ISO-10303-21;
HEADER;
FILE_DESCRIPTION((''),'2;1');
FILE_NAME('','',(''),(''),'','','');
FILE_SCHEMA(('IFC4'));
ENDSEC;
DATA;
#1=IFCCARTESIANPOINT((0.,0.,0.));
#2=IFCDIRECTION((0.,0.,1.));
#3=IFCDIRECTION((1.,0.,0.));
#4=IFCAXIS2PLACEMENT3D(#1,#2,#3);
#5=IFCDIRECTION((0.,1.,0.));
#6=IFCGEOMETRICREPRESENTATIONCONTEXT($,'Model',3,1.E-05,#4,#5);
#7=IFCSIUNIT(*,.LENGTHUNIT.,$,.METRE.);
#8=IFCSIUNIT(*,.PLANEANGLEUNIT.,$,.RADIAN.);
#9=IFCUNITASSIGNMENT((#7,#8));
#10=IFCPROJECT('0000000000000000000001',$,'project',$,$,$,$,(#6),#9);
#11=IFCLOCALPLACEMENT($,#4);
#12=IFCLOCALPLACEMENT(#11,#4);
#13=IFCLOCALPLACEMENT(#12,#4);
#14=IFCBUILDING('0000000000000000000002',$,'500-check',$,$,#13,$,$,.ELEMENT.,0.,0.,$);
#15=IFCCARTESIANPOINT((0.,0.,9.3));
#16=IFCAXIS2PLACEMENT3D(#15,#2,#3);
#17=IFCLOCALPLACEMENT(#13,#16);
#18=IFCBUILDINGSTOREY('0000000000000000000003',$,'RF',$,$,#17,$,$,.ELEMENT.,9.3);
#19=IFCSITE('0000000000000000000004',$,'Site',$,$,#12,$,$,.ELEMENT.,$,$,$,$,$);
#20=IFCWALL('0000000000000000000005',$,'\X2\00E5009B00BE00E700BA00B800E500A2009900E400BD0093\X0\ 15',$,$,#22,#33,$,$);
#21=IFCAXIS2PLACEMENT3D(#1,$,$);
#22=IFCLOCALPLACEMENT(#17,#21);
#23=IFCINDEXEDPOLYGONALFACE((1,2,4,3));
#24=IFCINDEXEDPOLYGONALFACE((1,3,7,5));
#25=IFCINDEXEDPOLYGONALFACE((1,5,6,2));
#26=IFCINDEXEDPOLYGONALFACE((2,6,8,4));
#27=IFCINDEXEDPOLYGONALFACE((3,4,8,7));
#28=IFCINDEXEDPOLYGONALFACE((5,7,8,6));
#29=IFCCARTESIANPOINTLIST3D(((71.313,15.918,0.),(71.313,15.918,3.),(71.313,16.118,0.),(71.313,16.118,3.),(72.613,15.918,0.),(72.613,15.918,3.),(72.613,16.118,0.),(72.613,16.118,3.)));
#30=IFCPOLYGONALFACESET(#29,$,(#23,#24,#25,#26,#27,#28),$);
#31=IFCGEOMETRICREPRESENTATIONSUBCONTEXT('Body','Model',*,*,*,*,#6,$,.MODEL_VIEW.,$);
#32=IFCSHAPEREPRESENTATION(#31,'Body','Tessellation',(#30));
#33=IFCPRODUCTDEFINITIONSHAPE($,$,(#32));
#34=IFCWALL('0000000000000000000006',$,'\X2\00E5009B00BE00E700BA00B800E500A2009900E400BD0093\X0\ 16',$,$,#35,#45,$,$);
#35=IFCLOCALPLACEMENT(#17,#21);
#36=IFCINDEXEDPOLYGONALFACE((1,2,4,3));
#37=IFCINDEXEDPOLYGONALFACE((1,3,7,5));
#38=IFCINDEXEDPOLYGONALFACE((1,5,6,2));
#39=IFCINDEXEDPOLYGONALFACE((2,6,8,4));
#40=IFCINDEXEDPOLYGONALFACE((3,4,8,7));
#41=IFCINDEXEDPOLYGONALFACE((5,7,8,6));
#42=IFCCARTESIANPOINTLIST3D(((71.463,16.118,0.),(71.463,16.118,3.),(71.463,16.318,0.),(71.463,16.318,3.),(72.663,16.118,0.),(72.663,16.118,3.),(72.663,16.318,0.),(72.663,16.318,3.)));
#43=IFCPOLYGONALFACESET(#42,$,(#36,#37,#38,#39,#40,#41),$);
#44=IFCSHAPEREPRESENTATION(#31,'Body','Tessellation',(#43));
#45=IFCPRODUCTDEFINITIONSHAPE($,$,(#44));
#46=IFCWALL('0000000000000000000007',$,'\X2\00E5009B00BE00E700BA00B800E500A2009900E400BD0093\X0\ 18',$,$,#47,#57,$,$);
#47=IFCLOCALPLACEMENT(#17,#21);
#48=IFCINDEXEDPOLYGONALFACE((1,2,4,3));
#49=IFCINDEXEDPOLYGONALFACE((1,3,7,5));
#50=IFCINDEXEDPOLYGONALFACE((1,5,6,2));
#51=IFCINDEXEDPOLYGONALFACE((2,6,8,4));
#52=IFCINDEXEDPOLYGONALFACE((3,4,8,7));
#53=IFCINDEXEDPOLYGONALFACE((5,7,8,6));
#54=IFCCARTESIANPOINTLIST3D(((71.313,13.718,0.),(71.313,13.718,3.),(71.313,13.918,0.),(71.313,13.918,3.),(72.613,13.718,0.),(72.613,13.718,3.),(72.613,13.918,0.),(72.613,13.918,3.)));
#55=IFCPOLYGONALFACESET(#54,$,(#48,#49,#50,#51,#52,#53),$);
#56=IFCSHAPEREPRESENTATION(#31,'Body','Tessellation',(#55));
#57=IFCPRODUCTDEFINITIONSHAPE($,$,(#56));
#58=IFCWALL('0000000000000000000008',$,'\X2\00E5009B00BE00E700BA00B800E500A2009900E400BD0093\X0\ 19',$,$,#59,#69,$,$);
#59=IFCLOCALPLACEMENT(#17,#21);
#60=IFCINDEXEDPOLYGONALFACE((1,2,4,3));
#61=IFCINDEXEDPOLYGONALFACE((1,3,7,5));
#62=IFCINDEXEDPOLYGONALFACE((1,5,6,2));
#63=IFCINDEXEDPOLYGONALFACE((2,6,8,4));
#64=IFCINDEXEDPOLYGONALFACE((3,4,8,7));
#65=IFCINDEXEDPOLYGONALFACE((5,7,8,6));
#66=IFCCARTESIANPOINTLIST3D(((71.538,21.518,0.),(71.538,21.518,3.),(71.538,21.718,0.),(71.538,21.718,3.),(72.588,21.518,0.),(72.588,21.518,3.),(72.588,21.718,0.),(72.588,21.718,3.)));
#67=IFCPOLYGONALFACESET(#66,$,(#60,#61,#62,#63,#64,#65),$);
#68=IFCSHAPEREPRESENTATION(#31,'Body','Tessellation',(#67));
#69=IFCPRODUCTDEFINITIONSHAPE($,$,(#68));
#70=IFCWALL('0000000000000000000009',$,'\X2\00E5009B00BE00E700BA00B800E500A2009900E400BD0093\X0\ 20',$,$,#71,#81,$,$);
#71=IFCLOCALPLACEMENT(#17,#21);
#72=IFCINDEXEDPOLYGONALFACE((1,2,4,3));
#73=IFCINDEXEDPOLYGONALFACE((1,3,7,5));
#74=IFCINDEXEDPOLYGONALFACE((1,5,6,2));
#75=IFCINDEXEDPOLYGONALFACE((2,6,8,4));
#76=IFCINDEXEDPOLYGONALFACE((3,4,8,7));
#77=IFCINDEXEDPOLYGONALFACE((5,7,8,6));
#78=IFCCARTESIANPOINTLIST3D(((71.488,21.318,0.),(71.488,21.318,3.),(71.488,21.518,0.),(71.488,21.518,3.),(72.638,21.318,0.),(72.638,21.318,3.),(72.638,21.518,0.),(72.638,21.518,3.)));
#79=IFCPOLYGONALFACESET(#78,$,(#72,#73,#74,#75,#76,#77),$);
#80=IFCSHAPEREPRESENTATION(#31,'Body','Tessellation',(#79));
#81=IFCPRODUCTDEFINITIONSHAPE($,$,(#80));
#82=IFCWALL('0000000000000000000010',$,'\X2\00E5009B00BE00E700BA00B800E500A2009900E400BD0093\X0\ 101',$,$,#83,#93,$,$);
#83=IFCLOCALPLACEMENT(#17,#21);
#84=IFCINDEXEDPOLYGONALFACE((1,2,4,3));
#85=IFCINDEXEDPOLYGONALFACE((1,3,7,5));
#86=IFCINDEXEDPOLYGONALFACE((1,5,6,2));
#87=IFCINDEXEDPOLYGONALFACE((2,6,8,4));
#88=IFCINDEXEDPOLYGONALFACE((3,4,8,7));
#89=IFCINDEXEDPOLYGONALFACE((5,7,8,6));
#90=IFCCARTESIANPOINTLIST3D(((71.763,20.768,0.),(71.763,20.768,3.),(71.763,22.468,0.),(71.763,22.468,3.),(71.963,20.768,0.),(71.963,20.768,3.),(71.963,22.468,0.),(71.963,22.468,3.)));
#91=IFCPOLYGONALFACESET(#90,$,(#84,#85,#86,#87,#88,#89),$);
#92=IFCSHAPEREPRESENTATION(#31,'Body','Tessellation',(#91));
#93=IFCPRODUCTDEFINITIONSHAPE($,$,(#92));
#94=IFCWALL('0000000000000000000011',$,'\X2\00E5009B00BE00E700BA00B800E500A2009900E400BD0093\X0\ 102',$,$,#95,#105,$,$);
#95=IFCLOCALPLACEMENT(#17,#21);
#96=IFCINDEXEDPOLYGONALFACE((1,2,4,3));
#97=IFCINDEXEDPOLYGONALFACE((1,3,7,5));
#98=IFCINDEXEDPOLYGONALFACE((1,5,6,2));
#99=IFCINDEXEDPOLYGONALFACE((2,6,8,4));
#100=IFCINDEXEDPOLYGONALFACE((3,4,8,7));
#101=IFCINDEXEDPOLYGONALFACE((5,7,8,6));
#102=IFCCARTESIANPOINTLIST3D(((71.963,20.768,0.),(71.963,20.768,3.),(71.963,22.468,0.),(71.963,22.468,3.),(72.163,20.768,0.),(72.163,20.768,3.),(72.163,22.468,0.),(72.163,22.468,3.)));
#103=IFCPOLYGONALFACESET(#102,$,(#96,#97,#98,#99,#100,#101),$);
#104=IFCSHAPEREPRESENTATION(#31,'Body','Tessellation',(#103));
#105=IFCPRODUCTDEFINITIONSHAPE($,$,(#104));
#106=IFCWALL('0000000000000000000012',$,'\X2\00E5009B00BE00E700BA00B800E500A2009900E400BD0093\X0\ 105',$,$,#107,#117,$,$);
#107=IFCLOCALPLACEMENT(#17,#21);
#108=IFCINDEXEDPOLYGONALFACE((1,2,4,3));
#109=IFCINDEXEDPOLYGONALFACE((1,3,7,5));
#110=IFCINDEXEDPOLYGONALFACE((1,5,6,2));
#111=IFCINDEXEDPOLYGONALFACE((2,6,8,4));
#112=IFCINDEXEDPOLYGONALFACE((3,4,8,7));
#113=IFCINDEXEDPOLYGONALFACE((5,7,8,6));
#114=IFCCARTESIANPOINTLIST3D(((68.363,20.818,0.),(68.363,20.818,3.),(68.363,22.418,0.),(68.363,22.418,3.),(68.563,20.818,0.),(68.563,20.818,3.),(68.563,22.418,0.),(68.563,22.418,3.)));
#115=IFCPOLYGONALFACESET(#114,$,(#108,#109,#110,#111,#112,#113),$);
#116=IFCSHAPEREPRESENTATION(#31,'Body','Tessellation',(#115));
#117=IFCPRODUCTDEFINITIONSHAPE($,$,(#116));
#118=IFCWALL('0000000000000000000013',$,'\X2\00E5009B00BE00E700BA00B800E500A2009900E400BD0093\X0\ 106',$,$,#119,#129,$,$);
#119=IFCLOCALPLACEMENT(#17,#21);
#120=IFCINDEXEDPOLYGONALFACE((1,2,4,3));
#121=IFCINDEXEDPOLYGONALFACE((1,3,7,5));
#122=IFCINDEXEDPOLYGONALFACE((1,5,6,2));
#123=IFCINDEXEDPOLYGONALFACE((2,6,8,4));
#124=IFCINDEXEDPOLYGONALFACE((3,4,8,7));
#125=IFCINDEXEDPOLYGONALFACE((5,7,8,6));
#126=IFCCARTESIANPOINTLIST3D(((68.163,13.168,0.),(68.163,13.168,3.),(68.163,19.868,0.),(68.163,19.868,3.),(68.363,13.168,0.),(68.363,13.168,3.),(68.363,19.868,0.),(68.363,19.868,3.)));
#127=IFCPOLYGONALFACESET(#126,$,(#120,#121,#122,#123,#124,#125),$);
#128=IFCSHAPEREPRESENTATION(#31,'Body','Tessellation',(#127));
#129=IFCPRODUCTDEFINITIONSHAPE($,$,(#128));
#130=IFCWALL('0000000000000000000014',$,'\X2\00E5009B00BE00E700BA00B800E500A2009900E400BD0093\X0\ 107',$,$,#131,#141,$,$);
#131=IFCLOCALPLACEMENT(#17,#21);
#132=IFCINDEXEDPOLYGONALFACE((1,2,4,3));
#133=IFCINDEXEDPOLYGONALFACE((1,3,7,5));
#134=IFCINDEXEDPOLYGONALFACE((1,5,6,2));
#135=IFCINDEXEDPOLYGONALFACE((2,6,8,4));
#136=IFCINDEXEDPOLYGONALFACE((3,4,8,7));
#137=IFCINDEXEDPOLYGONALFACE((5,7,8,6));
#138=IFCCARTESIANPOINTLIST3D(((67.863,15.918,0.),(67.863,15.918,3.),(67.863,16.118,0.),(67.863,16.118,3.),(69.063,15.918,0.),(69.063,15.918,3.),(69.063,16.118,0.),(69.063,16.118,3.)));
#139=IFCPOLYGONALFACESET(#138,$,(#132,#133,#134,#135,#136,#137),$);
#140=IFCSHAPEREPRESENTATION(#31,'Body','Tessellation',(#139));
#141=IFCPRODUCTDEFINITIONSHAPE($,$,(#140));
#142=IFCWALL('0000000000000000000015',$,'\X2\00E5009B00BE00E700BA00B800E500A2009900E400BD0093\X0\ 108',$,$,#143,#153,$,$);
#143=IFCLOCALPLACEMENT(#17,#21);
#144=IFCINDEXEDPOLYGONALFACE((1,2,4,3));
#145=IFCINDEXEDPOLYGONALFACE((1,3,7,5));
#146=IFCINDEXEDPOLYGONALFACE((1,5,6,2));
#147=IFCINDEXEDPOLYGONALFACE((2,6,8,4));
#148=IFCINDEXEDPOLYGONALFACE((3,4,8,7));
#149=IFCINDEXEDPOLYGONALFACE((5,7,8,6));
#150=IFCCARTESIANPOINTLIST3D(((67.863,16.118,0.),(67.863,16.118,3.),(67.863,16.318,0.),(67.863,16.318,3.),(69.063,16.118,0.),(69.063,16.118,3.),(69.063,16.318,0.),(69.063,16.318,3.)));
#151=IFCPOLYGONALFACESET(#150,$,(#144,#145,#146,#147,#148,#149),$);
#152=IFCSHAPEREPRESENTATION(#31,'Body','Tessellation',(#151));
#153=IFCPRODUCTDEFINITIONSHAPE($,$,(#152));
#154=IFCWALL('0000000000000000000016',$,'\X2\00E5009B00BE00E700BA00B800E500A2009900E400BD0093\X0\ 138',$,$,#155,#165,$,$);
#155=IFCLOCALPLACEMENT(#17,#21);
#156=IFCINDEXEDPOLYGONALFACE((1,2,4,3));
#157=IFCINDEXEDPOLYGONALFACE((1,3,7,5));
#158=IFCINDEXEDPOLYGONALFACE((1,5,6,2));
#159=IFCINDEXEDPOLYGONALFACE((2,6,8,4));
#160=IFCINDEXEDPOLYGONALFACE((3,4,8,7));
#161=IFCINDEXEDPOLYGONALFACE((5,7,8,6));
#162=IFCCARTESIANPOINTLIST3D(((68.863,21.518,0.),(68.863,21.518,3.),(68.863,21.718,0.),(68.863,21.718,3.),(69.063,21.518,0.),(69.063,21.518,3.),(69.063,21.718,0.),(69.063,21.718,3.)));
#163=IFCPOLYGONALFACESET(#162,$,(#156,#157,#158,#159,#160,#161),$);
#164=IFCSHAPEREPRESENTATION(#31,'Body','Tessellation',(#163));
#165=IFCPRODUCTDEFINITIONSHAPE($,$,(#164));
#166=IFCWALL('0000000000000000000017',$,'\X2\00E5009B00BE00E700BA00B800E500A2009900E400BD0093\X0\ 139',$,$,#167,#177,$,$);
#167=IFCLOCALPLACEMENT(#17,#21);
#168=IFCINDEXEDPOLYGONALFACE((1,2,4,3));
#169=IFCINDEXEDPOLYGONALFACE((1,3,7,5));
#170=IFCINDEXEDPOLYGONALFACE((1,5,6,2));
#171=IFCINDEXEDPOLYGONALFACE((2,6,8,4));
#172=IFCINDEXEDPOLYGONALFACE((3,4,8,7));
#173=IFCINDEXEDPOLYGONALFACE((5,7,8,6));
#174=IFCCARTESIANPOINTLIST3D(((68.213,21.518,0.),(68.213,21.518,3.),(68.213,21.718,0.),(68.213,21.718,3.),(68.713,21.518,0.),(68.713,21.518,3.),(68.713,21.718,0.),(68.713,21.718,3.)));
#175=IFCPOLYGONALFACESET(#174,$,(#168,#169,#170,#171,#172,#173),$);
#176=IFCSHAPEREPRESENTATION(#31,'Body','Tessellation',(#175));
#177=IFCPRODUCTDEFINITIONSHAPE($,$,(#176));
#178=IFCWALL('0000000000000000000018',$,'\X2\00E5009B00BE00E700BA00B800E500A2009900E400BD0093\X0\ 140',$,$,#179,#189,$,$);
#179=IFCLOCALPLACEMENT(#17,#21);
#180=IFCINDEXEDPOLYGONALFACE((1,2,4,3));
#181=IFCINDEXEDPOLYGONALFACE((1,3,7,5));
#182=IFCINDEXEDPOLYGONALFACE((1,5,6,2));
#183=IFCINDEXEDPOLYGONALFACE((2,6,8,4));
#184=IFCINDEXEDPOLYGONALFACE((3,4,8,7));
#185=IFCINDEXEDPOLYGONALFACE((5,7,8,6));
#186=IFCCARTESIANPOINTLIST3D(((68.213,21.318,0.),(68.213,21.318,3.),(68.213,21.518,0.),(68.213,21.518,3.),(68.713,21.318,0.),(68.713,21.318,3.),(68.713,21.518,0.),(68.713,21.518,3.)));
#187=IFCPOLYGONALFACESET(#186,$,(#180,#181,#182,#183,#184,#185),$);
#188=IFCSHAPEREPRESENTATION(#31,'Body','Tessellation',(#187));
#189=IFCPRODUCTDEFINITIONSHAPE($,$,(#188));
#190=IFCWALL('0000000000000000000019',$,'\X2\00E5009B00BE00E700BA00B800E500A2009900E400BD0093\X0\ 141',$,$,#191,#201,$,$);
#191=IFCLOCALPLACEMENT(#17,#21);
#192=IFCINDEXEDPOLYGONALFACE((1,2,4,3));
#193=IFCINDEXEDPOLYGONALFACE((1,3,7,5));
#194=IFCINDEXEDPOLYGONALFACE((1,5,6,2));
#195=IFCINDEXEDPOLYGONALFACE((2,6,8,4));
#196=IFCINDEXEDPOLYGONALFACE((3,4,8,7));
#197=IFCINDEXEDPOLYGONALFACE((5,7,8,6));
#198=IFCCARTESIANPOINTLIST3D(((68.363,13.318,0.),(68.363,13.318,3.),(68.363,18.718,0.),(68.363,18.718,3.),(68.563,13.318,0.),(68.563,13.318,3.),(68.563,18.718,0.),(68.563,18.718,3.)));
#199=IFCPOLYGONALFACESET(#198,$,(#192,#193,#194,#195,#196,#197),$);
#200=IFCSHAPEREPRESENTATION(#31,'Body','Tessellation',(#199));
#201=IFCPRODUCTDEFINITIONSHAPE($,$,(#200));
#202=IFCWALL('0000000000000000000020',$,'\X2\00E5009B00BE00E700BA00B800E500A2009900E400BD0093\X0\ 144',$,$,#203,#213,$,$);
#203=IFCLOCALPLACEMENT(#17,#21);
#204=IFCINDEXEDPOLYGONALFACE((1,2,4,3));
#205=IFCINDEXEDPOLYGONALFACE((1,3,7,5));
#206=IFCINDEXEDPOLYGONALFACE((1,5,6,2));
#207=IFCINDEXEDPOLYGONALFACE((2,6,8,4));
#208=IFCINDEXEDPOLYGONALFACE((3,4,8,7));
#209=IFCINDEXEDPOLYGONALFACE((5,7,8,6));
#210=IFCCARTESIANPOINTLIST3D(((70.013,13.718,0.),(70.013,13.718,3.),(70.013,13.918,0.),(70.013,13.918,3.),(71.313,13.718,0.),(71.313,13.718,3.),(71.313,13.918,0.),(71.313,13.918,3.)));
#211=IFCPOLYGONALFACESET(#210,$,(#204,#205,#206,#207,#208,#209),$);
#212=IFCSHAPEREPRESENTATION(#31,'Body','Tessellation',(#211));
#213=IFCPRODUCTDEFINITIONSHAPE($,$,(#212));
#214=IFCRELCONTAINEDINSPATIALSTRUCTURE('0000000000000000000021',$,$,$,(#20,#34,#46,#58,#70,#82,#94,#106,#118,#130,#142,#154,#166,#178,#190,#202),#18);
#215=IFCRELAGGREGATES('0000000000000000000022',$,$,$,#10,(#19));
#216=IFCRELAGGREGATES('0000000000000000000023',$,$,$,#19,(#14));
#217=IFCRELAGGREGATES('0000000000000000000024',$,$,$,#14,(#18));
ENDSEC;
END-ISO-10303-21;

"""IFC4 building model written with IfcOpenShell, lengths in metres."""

from ifc_helpers import new_model, si_unit, direction, frame, frame_2d, origin_with_axes, place, context, subcontext, project, spatial, rectangle, extrude, element, save


model = new_model("IFC4")

# Units and contexts
model_context = context("Model", 3, precision=1e-05, world=origin_with_axes(), true_north=direction((0.0, 1.0, 0.0)))
body_context = subcontext(model_context, "Body", "Model", "MODEL_VIEW")
ifc_project = project(units=[si_unit("LENGTHUNIT", "METRE"), si_unit("PLANEANGLEUNIT", "RADIAN")], contexts=[model_context])

# Site, building, storey
placement = place(None, origin_with_axes())
site_placement = place(placement, origin_with_axes())
site = spatial("IfcSite", under=ifc_project, at=site_placement, Name="Site", CompositionType="ELEMENT")
building_placement = place(site_placement, origin_with_axes())
building = spatial("IfcBuilding", under=site, at=building_placement, Name="500-check", CompositionType="ELEMENT", ElevationOfRefHeight=0.0, ElevationOfTerrain=0.0)
storey_placement = place(building_placement, frame((0.0, 0.0, 9.3), z_axis=(0.0, 0.0, 1.0), x_axis=(1.0, 0.0, 0.0)))
storey = spatial("IfcBuildingStorey", under=building, at=storey_placement, Name="RF", CompositionType="ELEMENT", Elevation=9.3)

# Walls
wall_1_placement = place(storey_placement, frame((71.963, 16.018, 0.0), z_axis=(0.0, 0.0, 1.0), x_axis=(1.0, 0.0, 0.0)))
element("IfcWall", 1, at=wall_1_placement, inside=storey, Name="å\u009b¾çº¸å¢\u0099ä½\u0093 15", context=body_context, shape_type="SweptSolid", body=[
    extrude(rectangle(XDim=1.3, YDim=0.2, at=frame_2d((0.0, 0.0), x_axis=(1.0, 0.0, 0.0))), frame((0.0, 0.0, 0.0), z_axis=(0.0, 0.0, 1.0)), (0.0, 0.0, 1.0), 3.0),
])
wall_2_placement = place(storey_placement, frame((72.063, 16.218, 0.0), z_axis=(0.0, 0.0, 1.0), x_axis=(1.0, 0.0, 0.0)))
element("IfcWall", 2, at=wall_2_placement, inside=storey, Name="å\u009b¾çº¸å¢\u0099ä½\u0093 16", context=body_context, shape_type="SweptSolid", body=[
    extrude(rectangle(XDim=1.2, YDim=0.2, at=frame_2d((0.0, 0.0), x_axis=(1.0, 0.0, 0.0))), frame((0.0, 0.0, 0.0), z_axis=(0.0, 0.0, 1.0)), (0.0, 0.0, 1.0), 3.0),
])
wall_3_placement = place(storey_placement, frame((71.963, 13.818, 0.0), z_axis=(0.0, 0.0, 1.0), x_axis=(1.0, 0.0, 0.0)))
element("IfcWall", 3, at=wall_3_placement, inside=storey, Name="å\u009b¾çº¸å¢\u0099ä½\u0093 18", context=body_context, shape_type="SweptSolid", body=[
    extrude(rectangle(XDim=1.3, YDim=0.2, at=frame_2d((0.0, 0.0), x_axis=(1.0, 0.0, 0.0))), frame((0.0, 0.0, 0.0), z_axis=(0.0, 0.0, 1.0)), (0.0, 0.0, 1.0), 3.0),
])
wall_4_placement = place(storey_placement, frame((72.063, 21.618, 0.0), z_axis=(0.0, 0.0, 1.0), x_axis=(1.0, 0.0, 0.0)))
element("IfcWall", 4, at=wall_4_placement, inside=storey, Name="å\u009b¾çº¸å¢\u0099ä½\u0093 19", context=body_context, shape_type="SweptSolid", body=[
    extrude(rectangle(XDim=1.05, YDim=0.2, at=frame_2d((0.0, 0.0), x_axis=(1.0, 0.0, 0.0))), frame((0.0, 0.0, 0.0), z_axis=(0.0, 0.0, 1.0)), (0.0, 0.0, 1.0), 3.0),
])
wall_5_placement = place(storey_placement, frame((72.063, 21.418, 0.0), z_axis=(0.0, 0.0, 1.0), x_axis=(1.0, 0.0, 0.0)))
element("IfcWall", 5, at=wall_5_placement, inside=storey, Name="å\u009b¾çº¸å¢\u0099ä½\u0093 20", context=body_context, shape_type="SweptSolid", body=[
    extrude(rectangle(XDim=1.15, YDim=0.2, at=frame_2d((0.0, 0.0), x_axis=(1.0, 0.0, 0.0))), frame((0.0, 0.0, 0.0), z_axis=(0.0, 0.0, 1.0)), (0.0, 0.0, 1.0), 3.0),
])
for number, where, z_axis, x_axis, name in (
    (6, (71.863, 21.618, 0.0), (0.0, 0.0, 1.0), (0.0, 1.0, 0.0), "å\u009b¾çº¸å¢\u0099ä½\u0093 101"),
    (7, (72.063, 21.618, 0.0), (0.0, 0.0, 1.0), (0.0, 1.0, 0.0), "å\u009b¾çº¸å¢\u0099ä½\u0093 102"),
):
    element("IfcWall", number, at=place(storey_placement, frame(where, z_axis=z_axis, x_axis=x_axis)), inside=storey, Name=name, context=body_context, shape_type="SweptSolid", body=[
        extrude(rectangle(XDim=1.7, YDim=0.2, at=frame_2d((0.0, 0.0), x_axis=(1.0, 0.0, 0.0))), frame((0.0, 0.0, 0.0), z_axis=(0.0, 0.0, 1.0)), (0.0, 0.0, 1.0), 3.0),
    ])
wall_6_placement = place(storey_placement, frame((68.463, 21.618, 0.0), z_axis=(0.0, 0.0, 1.0), x_axis=(0.0, 1.0, 0.0)))
element("IfcWall", 8, at=wall_6_placement, inside=storey, Name="å\u009b¾çº¸å¢\u0099ä½\u0093 105", context=body_context, shape_type="SweptSolid", body=[
    extrude(rectangle(XDim=1.6, YDim=0.2, at=frame_2d((0.0, 0.0), x_axis=(1.0, 0.0, 0.0))), frame((0.0, 0.0, 0.0), z_axis=(0.0, 0.0, 1.0)), (0.0, 0.0, 1.0), 3.0),
])
wall_7_placement = place(storey_placement, frame((68.263, 16.518, 0.0), z_axis=(0.0, 0.0, 1.0), x_axis=(0.0, 1.0, 0.0)))
element("IfcWall", 9, at=wall_7_placement, inside=storey, Name="å\u009b¾çº¸å¢\u0099ä½\u0093 106", context=body_context, shape_type="SweptSolid", body=[
    extrude(rectangle(XDim=6.7, YDim=0.2, at=frame_2d((0.0, 0.0), x_axis=(1.0, 0.0, 0.0))), frame((0.0, 0.0, 0.0), z_axis=(0.0, 0.0, 1.0)), (0.0, 0.0, 1.0), 3.0),
])
for number, where, z_axis, x_axis, name in (
    (10, (68.463, 16.018, 0.0), (0.0, 0.0, 1.0), (1.0, 0.0, 0.0), "å\u009b¾çº¸å¢\u0099ä½\u0093 107"),
    (11, (68.463, 16.218, 0.0), (0.0, 0.0, 1.0), (1.0, 0.0, 0.0), "å\u009b¾çº¸å¢\u0099ä½\u0093 108"),
):
    element("IfcWall", number, at=place(storey_placement, frame(where, z_axis=z_axis, x_axis=x_axis)), inside=storey, Name=name, context=body_context, shape_type="SweptSolid", body=[
        extrude(rectangle(XDim=1.2, YDim=0.2, at=frame_2d((0.0, 0.0), x_axis=(1.0, 0.0, 0.0))), frame((0.0, 0.0, 0.0), z_axis=(0.0, 0.0, 1.0)), (0.0, 0.0, 1.0), 3.0),
    ])
wall_8_placement = place(storey_placement, frame((68.963, 21.618, 0.0), z_axis=(0.0, 0.0, 1.0), x_axis=(0.0, -1.0, 0.0)))
element("IfcWall", 12, at=wall_8_placement, inside=storey, Name="å\u009b¾çº¸å¢\u0099ä½\u0093 138", context=body_context, shape_type="SweptSolid", body=[
    extrude(rectangle(XDim=0.2, YDim=0.2, at=frame_2d((0.0, 0.0), x_axis=(1.0, 0.0, 0.0))), frame((0.0, 0.0, 0.0), z_axis=(0.0, 0.0, 1.0)), (0.0, 0.0, 1.0), 3.0),
])
for number, where, z_axis, x_axis, name in (
    (13, (68.463, 21.618, 0.0), (0.0, 0.0, 1.0), (1.0, 0.0, 0.0), "å\u009b¾çº¸å¢\u0099ä½\u0093 139"),
    (14, (68.463, 21.418, 0.0), (0.0, 0.0, 1.0), (1.0, 0.0, 0.0), "å\u009b¾çº¸å¢\u0099ä½\u0093 140"),
):
    element("IfcWall", number, at=place(storey_placement, frame(where, z_axis=z_axis, x_axis=x_axis)), inside=storey, Name=name, context=body_context, shape_type="SweptSolid", body=[
        extrude(rectangle(XDim=0.5, YDim=0.2, at=frame_2d((0.0, 0.0), x_axis=(1.0, 0.0, 0.0))), frame((0.0, 0.0, 0.0), z_axis=(0.0, 0.0, 1.0)), (0.0, 0.0, 1.0), 3.0),
    ])
wall_9_placement = place(storey_placement, frame((68.463, 16.018, 0.0), z_axis=(0.0, 0.0, 1.0), x_axis=(0.0, 1.0, 0.0)))
element("IfcWall", 15, at=wall_9_placement, inside=storey, Name="å\u009b¾çº¸å¢\u0099ä½\u0093 141", context=body_context, shape_type="SweptSolid", body=[
    extrude(rectangle(XDim=5.4, YDim=0.2, at=frame_2d((0.0, 0.0), x_axis=(1.0, 0.0, 0.0))), frame((0.0, 0.0, 0.0), z_axis=(0.0, 0.0, 1.0)), (0.0, 0.0, 1.0), 3.0),
])
wall_10_placement = place(storey_placement, frame((70.663, 13.818, 0.0), z_axis=(0.0, 0.0, 1.0), x_axis=(1.0, 0.0, 0.0)))
element("IfcWall", 16, at=wall_10_placement, inside=storey, Name="å\u009b¾çº¸å¢\u0099ä½\u0093 144", context=body_context, shape_type="SweptSolid", body=[
    extrude(rectangle(XDim=1.3, YDim=0.2, at=frame_2d((0.0, 0.0), x_axis=(1.0, 0.0, 0.0))), frame((0.0, 0.0, 0.0), z_axis=(0.0, 0.0, 1.0)), (0.0, 0.0, 1.0), 3.0),
])

save(model, "model.ifc")
